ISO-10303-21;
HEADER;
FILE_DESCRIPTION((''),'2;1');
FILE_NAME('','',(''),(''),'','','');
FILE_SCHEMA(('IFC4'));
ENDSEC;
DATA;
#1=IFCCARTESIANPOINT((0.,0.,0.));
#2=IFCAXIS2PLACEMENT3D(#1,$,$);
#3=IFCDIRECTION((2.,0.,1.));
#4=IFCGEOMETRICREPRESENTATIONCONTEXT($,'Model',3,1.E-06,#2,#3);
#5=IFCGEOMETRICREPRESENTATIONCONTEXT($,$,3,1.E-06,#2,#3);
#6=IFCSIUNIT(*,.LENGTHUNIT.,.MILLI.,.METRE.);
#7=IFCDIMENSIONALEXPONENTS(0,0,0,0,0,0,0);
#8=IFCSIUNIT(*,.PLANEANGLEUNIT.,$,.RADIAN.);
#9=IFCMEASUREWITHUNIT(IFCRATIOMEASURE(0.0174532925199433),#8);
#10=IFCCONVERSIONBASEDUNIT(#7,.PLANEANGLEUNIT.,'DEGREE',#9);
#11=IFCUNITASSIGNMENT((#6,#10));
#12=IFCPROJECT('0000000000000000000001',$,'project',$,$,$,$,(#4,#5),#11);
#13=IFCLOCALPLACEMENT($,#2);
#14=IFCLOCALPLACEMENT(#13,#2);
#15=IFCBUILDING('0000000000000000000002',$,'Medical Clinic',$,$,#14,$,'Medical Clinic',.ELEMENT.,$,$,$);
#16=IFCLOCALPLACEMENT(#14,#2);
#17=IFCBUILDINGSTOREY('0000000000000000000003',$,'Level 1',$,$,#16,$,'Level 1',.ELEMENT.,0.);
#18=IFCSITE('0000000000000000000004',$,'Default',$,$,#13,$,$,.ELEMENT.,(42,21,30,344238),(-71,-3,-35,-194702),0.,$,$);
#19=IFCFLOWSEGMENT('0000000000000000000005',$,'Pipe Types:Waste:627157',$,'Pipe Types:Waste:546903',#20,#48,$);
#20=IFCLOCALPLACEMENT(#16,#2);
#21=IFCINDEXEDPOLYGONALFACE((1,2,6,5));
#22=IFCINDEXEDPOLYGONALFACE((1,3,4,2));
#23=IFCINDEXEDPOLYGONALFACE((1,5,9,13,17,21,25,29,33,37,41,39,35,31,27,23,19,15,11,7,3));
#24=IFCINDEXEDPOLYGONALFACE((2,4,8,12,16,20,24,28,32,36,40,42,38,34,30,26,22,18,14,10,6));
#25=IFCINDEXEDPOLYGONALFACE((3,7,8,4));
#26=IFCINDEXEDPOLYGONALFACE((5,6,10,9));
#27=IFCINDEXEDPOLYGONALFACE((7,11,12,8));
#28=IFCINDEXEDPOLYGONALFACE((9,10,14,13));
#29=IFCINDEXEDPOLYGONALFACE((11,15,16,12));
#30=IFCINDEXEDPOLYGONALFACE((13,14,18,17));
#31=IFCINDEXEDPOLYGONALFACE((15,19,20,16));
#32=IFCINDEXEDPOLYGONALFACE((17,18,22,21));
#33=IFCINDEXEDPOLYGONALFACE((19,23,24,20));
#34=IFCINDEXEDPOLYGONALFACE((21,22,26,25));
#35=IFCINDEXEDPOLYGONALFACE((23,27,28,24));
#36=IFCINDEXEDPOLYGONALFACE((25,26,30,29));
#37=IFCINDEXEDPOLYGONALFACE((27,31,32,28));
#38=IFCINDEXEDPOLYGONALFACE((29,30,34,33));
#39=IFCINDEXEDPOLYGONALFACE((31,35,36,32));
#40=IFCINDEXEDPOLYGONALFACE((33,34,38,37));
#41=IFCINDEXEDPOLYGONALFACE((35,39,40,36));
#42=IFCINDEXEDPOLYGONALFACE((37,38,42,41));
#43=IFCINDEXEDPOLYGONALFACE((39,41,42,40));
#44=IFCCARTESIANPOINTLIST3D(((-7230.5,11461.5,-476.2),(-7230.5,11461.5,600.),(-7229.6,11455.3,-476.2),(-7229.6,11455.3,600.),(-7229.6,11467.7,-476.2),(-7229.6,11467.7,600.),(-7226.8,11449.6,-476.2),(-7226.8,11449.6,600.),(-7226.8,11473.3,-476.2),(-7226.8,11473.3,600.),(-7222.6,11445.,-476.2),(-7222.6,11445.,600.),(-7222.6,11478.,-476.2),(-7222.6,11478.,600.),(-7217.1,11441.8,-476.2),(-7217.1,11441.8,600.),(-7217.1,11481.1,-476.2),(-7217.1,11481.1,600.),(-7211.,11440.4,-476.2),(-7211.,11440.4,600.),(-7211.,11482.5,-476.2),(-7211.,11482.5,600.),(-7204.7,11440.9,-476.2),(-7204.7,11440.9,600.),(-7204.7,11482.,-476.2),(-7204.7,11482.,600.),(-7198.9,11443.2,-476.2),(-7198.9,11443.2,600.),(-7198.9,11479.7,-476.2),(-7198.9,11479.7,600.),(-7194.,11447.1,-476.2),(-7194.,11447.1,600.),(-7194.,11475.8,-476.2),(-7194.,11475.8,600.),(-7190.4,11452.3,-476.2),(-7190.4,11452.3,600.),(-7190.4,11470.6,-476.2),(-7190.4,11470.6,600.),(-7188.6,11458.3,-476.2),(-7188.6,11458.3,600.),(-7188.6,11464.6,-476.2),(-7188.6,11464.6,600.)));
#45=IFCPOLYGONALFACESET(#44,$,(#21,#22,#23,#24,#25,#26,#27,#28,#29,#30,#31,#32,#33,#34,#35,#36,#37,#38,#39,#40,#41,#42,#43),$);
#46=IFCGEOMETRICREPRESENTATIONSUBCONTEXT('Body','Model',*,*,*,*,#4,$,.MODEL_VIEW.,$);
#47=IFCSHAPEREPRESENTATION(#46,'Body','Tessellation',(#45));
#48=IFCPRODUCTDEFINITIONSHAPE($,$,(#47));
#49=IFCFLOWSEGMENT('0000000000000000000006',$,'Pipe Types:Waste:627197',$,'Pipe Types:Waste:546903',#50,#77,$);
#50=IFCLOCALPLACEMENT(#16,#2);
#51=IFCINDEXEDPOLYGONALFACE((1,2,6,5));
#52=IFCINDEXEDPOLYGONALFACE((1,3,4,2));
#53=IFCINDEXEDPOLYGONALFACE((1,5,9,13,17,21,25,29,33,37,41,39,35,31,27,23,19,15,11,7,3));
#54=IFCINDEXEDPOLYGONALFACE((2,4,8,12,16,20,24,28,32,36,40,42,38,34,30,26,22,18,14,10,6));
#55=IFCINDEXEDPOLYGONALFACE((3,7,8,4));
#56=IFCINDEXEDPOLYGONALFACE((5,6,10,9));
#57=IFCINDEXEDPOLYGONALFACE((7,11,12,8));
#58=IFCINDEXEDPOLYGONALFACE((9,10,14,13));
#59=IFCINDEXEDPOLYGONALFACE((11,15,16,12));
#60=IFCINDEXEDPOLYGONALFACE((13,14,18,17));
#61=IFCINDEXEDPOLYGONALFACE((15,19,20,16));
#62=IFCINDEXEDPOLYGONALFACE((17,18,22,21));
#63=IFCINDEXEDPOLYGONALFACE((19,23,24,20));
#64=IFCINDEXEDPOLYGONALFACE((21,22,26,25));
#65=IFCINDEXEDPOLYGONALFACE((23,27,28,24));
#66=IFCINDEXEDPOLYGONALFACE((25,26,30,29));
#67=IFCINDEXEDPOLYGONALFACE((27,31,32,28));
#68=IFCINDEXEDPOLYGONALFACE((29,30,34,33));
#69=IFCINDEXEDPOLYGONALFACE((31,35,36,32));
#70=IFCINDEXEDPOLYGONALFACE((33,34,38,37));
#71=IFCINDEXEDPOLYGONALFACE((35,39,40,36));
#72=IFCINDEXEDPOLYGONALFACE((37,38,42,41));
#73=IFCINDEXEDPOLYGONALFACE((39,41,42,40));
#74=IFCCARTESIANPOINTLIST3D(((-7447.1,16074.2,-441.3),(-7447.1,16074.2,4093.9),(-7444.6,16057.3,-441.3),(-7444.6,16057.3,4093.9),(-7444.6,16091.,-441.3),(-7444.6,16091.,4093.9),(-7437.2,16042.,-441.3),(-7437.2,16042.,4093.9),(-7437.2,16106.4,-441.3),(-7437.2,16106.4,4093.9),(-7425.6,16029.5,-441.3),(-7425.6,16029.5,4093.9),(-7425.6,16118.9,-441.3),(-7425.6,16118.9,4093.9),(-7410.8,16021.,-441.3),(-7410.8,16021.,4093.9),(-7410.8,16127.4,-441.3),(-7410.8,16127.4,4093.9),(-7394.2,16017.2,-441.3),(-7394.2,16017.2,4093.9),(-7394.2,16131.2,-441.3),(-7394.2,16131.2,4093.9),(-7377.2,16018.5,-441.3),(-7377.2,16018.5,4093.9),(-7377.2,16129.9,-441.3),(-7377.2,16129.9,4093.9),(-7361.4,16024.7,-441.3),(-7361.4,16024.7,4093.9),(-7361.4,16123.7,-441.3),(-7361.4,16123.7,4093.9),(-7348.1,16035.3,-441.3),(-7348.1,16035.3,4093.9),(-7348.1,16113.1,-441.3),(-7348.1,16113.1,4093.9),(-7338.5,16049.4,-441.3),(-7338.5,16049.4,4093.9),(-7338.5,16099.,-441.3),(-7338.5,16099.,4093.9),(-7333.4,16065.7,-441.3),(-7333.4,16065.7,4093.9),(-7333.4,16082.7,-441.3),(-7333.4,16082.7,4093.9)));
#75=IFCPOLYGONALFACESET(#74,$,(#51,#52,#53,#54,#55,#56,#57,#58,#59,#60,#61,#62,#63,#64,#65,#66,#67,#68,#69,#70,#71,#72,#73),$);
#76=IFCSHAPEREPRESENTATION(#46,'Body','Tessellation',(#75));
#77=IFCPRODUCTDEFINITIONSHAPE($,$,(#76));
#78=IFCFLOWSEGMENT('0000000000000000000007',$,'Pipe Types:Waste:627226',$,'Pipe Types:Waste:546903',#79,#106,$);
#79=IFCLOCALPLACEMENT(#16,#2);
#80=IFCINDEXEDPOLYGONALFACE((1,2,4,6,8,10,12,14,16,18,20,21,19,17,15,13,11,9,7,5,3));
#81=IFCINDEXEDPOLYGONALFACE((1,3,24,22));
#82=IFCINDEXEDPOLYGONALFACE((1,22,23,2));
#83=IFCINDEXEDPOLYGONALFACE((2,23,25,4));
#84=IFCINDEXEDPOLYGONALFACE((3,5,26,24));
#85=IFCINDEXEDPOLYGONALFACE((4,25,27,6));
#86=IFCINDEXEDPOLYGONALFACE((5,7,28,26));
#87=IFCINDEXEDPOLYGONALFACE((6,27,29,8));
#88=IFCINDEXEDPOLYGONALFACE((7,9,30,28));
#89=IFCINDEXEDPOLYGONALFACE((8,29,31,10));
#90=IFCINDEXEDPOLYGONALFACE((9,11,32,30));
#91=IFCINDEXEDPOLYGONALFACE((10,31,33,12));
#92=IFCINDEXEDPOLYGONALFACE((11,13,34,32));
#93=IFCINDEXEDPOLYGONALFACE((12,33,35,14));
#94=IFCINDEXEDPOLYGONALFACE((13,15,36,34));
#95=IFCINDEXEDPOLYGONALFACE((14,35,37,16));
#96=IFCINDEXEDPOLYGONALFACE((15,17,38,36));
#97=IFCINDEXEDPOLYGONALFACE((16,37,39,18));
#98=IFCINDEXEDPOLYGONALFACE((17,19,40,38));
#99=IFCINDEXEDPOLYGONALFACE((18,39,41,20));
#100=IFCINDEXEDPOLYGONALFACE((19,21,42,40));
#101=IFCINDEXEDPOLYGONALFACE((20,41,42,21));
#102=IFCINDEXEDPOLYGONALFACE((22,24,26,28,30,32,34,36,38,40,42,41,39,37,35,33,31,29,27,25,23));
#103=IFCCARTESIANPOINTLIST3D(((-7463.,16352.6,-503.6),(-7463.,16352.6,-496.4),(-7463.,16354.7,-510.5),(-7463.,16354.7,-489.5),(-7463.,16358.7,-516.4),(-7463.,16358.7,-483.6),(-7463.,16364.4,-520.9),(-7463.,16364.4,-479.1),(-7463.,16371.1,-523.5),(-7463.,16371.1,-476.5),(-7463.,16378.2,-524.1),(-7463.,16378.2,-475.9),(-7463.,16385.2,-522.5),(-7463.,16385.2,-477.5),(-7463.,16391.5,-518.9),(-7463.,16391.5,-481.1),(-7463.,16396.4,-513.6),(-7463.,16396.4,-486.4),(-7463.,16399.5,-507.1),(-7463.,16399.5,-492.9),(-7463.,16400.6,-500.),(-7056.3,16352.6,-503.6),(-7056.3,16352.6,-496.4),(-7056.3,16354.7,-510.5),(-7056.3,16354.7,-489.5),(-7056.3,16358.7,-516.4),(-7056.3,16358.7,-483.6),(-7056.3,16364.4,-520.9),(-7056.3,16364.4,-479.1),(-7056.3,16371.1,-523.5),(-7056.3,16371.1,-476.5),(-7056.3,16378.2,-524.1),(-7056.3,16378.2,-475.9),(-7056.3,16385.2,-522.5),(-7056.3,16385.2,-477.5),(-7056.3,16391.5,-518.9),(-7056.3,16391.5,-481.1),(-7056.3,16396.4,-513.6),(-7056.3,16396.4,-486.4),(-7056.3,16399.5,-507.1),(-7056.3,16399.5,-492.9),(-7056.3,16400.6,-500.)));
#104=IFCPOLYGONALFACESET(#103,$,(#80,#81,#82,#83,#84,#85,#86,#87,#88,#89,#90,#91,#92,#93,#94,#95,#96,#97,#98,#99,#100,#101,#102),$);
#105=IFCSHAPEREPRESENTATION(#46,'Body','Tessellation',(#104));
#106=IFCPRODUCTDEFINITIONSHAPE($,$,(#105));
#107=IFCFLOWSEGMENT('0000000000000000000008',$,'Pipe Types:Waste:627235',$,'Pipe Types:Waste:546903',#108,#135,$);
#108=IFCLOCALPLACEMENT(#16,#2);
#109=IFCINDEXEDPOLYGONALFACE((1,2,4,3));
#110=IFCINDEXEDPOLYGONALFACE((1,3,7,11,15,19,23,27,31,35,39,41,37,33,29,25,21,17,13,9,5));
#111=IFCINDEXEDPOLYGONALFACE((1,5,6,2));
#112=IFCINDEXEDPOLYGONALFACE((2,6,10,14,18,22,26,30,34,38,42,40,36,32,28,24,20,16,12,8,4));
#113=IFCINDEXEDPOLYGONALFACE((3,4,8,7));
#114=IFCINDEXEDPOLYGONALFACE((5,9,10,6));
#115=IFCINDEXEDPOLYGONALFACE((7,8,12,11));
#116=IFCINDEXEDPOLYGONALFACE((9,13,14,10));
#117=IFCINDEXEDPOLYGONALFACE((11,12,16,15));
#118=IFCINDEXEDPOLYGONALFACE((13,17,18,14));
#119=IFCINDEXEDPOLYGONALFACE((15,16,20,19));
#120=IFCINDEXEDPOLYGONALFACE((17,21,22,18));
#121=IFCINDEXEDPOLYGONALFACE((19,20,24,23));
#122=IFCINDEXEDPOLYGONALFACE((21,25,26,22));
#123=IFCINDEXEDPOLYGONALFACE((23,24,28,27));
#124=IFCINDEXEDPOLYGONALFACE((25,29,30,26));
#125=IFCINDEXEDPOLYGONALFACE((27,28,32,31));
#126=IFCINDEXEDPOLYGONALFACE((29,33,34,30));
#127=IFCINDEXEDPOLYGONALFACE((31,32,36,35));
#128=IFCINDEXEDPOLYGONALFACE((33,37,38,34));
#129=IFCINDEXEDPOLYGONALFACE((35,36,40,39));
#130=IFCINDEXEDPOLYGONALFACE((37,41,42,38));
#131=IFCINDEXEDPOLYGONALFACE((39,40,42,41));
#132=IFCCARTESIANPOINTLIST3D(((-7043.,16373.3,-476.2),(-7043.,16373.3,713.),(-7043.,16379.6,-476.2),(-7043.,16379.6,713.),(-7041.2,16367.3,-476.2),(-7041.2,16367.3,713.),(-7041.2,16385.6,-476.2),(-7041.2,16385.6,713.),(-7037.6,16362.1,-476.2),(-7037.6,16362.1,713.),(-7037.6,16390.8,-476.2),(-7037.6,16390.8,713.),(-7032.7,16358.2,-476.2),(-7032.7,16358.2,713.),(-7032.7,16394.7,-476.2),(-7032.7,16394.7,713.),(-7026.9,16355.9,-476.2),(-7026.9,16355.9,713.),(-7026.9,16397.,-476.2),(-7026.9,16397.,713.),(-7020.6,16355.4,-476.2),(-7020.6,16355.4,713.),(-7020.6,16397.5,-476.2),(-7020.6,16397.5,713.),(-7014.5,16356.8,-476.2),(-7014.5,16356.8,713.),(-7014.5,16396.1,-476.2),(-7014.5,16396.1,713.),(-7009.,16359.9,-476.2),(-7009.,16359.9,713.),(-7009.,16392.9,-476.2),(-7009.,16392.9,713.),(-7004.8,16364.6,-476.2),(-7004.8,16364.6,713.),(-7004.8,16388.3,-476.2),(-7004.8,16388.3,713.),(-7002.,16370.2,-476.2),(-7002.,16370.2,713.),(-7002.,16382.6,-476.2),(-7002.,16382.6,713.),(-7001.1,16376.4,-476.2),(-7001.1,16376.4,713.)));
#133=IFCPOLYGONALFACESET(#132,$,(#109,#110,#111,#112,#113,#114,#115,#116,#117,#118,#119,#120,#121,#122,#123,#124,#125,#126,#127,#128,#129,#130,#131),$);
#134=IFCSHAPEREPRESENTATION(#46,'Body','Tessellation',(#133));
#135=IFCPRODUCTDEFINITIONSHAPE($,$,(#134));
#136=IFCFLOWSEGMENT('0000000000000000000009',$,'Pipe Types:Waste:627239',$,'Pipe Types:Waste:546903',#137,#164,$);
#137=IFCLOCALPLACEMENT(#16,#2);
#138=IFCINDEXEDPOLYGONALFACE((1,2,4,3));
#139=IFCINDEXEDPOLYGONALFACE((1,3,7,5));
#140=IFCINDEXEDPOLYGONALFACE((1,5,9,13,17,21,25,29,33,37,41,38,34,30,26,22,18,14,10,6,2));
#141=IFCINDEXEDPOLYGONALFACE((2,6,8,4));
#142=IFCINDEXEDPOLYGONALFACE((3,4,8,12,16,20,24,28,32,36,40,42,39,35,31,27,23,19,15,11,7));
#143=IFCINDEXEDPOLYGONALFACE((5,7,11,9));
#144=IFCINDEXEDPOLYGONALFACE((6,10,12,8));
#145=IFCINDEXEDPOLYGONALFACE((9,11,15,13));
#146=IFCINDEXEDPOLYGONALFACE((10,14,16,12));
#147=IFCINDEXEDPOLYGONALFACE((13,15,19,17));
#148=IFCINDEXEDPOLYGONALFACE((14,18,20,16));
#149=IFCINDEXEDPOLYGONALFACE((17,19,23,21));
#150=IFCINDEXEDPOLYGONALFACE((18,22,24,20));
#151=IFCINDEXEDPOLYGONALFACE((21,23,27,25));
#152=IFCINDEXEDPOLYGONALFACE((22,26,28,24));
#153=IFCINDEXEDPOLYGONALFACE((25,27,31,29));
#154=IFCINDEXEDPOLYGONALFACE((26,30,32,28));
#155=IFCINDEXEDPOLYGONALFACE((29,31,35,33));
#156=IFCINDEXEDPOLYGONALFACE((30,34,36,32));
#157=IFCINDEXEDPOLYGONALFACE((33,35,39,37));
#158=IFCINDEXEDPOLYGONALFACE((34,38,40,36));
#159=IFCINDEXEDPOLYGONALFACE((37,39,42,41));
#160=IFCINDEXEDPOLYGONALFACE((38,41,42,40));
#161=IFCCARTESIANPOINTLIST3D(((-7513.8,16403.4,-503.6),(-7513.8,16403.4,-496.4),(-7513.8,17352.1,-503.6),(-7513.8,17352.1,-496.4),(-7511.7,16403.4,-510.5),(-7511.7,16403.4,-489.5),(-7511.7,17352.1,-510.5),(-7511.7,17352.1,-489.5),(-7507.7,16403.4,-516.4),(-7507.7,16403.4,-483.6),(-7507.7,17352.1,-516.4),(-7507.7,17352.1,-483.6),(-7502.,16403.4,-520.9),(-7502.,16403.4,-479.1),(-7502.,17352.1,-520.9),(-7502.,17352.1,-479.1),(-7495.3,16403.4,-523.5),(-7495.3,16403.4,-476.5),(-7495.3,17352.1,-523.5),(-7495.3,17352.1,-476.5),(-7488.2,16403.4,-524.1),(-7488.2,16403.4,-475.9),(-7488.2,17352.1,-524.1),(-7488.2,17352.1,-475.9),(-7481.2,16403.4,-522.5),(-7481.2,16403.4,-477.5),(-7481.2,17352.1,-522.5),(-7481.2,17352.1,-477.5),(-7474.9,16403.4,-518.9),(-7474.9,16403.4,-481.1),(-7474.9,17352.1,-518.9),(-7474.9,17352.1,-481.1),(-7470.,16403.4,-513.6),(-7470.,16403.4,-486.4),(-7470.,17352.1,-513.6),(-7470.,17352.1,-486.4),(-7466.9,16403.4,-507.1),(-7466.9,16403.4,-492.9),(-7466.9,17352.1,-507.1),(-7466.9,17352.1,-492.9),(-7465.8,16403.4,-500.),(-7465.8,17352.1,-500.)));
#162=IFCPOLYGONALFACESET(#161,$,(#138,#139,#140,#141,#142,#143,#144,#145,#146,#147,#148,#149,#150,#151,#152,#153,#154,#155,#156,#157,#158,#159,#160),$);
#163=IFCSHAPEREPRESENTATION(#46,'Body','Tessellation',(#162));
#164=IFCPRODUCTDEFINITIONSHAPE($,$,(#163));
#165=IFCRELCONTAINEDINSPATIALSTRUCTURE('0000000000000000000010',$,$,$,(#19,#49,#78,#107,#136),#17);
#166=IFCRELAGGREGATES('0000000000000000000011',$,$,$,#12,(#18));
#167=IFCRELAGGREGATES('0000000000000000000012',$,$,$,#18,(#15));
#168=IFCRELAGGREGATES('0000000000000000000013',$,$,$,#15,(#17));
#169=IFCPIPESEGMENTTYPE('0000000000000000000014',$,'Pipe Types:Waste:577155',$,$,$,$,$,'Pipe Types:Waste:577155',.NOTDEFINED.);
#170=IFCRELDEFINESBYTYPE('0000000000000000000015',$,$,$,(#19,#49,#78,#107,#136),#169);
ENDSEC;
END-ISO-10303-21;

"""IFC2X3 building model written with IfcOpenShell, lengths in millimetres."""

from ifc_helpers import new_model, entity, si_unit, converted_unit, direction, frame, frame_2d, origin, origin_2d_with_axis, place, context, subcontext, project, spatial, circle, extrude, type_object, element, save


model = new_model("IFC2X3")

# Units and contexts
model_context = context("Model", 3, precision=1e-06, world=origin(), true_north=direction((2.0, 0.0, 1.0)))
context_of_model = context(None, 3, precision=1e-06, world=origin(), true_north=direction((2.0, 0.0, 1.0)))
body_context = subcontext(model_context, "Body", "Model", "MODEL_VIEW")
ifc_project = project(units=[si_unit("LENGTHUNIT", "METRE", prefix="MILLI"), converted_unit("PLANEANGLEUNIT", "DEGREE", entity("IfcRatioMeasure", 0.0174532925199433), si_unit("PLANEANGLEUNIT", "RADIAN"), dimensions=[0, 0, 0, 0, 0, 0, 0])], contexts=[model_context, context_of_model])

# Site, building, storey
site_placement = place(None, origin())
site = spatial("IfcSite", under=ifc_project, at=site_placement, Name="Default", CompositionType="ELEMENT", RefLatitude=(42, 21, 30, 344238), RefLongitude=(-71, -3, -35, -194702), RefElevation=0.0)
building_placement = place(site_placement, origin())
building = spatial("IfcBuilding", under=site, at=building_placement, Name="Medical Clinic", LongName="Medical Clinic", CompositionType="ELEMENT")
storey_placement = place(building_placement, origin())
storey = spatial("IfcBuildingStorey", under=building, at=storey_placement, Name="Level 1", LongName="Level 1", CompositionType="ELEMENT", Elevation=0.0)

# Flow segments
pipe_segment_type = type_object("IfcPipeSegmentType", Name="Pipe Types:Waste:577155", ElementType="Pipe Types:Waste:577155", PredefinedType="NOTDEFINED")
flow_segment_1_placement = place(storey_placement, origin())
element("IfcFlowSegment", 1, at=flow_segment_1_placement, inside=storey, type_object=pipe_segment_type, Name="Pipe Types:Waste:627157", ObjectType="Pipe Types:Waste:546903", context=body_context, shape_type="SweptSolid", body=[
    extrude(circle(Radius=21.1, at=origin_2d_with_axis()), frame((-7209.4, 11461.5, -476.2), z_axis=(0.0, 0.0, 1.0), x_axis=(-1.0, 0.0, 0.0)), (0.0, 0.0, 1.0), 1076.2),
])
flow_segment_2_placement = place(storey_placement, origin())
element("IfcFlowSegment", 2, at=flow_segment_2_placement, inside=storey, type_object=pipe_segment_type, Name="Pipe Types:Waste:627197", ObjectType="Pipe Types:Waste:546903", context=body_context, shape_type="SweptSolid", body=[
    extrude(circle(Radius=57.1, at=origin_2d_with_axis()), frame((-7389.9, 16074.2, -441.3), z_axis=(0.0, 0.0, 1.0), x_axis=(-1.0, 0.0, 0.0)), (0.0, 0.0, 1.0), 4535.2),
])
flow_segment_3_placement = place(storey_placement, origin())
element("IfcFlowSegment", 3, at=flow_segment_3_placement, inside=storey, type_object=pipe_segment_type, Name="Pipe Types:Waste:627226", ObjectType="Pipe Types:Waste:546903", context=body_context, shape_type="SweptSolid", body=[
    extrude(circle(Radius=24.1, at=frame_2d((0.0, 0.0), x_axis=(1.0, 0.0))), frame((-7463.0, 16376.4, -500.0), z_axis=(1.0, 0.0, 0.0), x_axis=(0.0, 1.0, 0.0)), (0.0, 0.0, 1.0), 406.7),
])
flow_segment_4_placement = place(storey_placement, origin())
element("IfcFlowSegment", 4, at=flow_segment_4_placement, inside=storey, type_object=pipe_segment_type, Name="Pipe Types:Waste:627235", ObjectType="Pipe Types:Waste:546903", context=body_context, shape_type="SweptSolid", body=[
    extrude(circle(Radius=21.1, at=origin_2d_with_axis()), frame((-7022.2, 16376.4, -476.2)), (0.0, 0.0, 1.0), 1189.2),
])
flow_segment_5_placement = place(storey_placement, origin())
element("IfcFlowSegment", 5, at=flow_segment_5_placement, inside=storey, type_object=pipe_segment_type, Name="Pipe Types:Waste:627239", ObjectType="Pipe Types:Waste:546903", context=body_context, shape_type="SweptSolid", body=[
    extrude(circle(Radius=24.1, at=origin_2d_with_axis()), frame((-7490.0, 16403.4, -500.0), z_axis=(0.0, 1.0, 0.0), x_axis=(1.0, 0.0, 0.0)), (0.0, 0.0, 1.0), 948.7),
])

save(model, "model.ifc")
